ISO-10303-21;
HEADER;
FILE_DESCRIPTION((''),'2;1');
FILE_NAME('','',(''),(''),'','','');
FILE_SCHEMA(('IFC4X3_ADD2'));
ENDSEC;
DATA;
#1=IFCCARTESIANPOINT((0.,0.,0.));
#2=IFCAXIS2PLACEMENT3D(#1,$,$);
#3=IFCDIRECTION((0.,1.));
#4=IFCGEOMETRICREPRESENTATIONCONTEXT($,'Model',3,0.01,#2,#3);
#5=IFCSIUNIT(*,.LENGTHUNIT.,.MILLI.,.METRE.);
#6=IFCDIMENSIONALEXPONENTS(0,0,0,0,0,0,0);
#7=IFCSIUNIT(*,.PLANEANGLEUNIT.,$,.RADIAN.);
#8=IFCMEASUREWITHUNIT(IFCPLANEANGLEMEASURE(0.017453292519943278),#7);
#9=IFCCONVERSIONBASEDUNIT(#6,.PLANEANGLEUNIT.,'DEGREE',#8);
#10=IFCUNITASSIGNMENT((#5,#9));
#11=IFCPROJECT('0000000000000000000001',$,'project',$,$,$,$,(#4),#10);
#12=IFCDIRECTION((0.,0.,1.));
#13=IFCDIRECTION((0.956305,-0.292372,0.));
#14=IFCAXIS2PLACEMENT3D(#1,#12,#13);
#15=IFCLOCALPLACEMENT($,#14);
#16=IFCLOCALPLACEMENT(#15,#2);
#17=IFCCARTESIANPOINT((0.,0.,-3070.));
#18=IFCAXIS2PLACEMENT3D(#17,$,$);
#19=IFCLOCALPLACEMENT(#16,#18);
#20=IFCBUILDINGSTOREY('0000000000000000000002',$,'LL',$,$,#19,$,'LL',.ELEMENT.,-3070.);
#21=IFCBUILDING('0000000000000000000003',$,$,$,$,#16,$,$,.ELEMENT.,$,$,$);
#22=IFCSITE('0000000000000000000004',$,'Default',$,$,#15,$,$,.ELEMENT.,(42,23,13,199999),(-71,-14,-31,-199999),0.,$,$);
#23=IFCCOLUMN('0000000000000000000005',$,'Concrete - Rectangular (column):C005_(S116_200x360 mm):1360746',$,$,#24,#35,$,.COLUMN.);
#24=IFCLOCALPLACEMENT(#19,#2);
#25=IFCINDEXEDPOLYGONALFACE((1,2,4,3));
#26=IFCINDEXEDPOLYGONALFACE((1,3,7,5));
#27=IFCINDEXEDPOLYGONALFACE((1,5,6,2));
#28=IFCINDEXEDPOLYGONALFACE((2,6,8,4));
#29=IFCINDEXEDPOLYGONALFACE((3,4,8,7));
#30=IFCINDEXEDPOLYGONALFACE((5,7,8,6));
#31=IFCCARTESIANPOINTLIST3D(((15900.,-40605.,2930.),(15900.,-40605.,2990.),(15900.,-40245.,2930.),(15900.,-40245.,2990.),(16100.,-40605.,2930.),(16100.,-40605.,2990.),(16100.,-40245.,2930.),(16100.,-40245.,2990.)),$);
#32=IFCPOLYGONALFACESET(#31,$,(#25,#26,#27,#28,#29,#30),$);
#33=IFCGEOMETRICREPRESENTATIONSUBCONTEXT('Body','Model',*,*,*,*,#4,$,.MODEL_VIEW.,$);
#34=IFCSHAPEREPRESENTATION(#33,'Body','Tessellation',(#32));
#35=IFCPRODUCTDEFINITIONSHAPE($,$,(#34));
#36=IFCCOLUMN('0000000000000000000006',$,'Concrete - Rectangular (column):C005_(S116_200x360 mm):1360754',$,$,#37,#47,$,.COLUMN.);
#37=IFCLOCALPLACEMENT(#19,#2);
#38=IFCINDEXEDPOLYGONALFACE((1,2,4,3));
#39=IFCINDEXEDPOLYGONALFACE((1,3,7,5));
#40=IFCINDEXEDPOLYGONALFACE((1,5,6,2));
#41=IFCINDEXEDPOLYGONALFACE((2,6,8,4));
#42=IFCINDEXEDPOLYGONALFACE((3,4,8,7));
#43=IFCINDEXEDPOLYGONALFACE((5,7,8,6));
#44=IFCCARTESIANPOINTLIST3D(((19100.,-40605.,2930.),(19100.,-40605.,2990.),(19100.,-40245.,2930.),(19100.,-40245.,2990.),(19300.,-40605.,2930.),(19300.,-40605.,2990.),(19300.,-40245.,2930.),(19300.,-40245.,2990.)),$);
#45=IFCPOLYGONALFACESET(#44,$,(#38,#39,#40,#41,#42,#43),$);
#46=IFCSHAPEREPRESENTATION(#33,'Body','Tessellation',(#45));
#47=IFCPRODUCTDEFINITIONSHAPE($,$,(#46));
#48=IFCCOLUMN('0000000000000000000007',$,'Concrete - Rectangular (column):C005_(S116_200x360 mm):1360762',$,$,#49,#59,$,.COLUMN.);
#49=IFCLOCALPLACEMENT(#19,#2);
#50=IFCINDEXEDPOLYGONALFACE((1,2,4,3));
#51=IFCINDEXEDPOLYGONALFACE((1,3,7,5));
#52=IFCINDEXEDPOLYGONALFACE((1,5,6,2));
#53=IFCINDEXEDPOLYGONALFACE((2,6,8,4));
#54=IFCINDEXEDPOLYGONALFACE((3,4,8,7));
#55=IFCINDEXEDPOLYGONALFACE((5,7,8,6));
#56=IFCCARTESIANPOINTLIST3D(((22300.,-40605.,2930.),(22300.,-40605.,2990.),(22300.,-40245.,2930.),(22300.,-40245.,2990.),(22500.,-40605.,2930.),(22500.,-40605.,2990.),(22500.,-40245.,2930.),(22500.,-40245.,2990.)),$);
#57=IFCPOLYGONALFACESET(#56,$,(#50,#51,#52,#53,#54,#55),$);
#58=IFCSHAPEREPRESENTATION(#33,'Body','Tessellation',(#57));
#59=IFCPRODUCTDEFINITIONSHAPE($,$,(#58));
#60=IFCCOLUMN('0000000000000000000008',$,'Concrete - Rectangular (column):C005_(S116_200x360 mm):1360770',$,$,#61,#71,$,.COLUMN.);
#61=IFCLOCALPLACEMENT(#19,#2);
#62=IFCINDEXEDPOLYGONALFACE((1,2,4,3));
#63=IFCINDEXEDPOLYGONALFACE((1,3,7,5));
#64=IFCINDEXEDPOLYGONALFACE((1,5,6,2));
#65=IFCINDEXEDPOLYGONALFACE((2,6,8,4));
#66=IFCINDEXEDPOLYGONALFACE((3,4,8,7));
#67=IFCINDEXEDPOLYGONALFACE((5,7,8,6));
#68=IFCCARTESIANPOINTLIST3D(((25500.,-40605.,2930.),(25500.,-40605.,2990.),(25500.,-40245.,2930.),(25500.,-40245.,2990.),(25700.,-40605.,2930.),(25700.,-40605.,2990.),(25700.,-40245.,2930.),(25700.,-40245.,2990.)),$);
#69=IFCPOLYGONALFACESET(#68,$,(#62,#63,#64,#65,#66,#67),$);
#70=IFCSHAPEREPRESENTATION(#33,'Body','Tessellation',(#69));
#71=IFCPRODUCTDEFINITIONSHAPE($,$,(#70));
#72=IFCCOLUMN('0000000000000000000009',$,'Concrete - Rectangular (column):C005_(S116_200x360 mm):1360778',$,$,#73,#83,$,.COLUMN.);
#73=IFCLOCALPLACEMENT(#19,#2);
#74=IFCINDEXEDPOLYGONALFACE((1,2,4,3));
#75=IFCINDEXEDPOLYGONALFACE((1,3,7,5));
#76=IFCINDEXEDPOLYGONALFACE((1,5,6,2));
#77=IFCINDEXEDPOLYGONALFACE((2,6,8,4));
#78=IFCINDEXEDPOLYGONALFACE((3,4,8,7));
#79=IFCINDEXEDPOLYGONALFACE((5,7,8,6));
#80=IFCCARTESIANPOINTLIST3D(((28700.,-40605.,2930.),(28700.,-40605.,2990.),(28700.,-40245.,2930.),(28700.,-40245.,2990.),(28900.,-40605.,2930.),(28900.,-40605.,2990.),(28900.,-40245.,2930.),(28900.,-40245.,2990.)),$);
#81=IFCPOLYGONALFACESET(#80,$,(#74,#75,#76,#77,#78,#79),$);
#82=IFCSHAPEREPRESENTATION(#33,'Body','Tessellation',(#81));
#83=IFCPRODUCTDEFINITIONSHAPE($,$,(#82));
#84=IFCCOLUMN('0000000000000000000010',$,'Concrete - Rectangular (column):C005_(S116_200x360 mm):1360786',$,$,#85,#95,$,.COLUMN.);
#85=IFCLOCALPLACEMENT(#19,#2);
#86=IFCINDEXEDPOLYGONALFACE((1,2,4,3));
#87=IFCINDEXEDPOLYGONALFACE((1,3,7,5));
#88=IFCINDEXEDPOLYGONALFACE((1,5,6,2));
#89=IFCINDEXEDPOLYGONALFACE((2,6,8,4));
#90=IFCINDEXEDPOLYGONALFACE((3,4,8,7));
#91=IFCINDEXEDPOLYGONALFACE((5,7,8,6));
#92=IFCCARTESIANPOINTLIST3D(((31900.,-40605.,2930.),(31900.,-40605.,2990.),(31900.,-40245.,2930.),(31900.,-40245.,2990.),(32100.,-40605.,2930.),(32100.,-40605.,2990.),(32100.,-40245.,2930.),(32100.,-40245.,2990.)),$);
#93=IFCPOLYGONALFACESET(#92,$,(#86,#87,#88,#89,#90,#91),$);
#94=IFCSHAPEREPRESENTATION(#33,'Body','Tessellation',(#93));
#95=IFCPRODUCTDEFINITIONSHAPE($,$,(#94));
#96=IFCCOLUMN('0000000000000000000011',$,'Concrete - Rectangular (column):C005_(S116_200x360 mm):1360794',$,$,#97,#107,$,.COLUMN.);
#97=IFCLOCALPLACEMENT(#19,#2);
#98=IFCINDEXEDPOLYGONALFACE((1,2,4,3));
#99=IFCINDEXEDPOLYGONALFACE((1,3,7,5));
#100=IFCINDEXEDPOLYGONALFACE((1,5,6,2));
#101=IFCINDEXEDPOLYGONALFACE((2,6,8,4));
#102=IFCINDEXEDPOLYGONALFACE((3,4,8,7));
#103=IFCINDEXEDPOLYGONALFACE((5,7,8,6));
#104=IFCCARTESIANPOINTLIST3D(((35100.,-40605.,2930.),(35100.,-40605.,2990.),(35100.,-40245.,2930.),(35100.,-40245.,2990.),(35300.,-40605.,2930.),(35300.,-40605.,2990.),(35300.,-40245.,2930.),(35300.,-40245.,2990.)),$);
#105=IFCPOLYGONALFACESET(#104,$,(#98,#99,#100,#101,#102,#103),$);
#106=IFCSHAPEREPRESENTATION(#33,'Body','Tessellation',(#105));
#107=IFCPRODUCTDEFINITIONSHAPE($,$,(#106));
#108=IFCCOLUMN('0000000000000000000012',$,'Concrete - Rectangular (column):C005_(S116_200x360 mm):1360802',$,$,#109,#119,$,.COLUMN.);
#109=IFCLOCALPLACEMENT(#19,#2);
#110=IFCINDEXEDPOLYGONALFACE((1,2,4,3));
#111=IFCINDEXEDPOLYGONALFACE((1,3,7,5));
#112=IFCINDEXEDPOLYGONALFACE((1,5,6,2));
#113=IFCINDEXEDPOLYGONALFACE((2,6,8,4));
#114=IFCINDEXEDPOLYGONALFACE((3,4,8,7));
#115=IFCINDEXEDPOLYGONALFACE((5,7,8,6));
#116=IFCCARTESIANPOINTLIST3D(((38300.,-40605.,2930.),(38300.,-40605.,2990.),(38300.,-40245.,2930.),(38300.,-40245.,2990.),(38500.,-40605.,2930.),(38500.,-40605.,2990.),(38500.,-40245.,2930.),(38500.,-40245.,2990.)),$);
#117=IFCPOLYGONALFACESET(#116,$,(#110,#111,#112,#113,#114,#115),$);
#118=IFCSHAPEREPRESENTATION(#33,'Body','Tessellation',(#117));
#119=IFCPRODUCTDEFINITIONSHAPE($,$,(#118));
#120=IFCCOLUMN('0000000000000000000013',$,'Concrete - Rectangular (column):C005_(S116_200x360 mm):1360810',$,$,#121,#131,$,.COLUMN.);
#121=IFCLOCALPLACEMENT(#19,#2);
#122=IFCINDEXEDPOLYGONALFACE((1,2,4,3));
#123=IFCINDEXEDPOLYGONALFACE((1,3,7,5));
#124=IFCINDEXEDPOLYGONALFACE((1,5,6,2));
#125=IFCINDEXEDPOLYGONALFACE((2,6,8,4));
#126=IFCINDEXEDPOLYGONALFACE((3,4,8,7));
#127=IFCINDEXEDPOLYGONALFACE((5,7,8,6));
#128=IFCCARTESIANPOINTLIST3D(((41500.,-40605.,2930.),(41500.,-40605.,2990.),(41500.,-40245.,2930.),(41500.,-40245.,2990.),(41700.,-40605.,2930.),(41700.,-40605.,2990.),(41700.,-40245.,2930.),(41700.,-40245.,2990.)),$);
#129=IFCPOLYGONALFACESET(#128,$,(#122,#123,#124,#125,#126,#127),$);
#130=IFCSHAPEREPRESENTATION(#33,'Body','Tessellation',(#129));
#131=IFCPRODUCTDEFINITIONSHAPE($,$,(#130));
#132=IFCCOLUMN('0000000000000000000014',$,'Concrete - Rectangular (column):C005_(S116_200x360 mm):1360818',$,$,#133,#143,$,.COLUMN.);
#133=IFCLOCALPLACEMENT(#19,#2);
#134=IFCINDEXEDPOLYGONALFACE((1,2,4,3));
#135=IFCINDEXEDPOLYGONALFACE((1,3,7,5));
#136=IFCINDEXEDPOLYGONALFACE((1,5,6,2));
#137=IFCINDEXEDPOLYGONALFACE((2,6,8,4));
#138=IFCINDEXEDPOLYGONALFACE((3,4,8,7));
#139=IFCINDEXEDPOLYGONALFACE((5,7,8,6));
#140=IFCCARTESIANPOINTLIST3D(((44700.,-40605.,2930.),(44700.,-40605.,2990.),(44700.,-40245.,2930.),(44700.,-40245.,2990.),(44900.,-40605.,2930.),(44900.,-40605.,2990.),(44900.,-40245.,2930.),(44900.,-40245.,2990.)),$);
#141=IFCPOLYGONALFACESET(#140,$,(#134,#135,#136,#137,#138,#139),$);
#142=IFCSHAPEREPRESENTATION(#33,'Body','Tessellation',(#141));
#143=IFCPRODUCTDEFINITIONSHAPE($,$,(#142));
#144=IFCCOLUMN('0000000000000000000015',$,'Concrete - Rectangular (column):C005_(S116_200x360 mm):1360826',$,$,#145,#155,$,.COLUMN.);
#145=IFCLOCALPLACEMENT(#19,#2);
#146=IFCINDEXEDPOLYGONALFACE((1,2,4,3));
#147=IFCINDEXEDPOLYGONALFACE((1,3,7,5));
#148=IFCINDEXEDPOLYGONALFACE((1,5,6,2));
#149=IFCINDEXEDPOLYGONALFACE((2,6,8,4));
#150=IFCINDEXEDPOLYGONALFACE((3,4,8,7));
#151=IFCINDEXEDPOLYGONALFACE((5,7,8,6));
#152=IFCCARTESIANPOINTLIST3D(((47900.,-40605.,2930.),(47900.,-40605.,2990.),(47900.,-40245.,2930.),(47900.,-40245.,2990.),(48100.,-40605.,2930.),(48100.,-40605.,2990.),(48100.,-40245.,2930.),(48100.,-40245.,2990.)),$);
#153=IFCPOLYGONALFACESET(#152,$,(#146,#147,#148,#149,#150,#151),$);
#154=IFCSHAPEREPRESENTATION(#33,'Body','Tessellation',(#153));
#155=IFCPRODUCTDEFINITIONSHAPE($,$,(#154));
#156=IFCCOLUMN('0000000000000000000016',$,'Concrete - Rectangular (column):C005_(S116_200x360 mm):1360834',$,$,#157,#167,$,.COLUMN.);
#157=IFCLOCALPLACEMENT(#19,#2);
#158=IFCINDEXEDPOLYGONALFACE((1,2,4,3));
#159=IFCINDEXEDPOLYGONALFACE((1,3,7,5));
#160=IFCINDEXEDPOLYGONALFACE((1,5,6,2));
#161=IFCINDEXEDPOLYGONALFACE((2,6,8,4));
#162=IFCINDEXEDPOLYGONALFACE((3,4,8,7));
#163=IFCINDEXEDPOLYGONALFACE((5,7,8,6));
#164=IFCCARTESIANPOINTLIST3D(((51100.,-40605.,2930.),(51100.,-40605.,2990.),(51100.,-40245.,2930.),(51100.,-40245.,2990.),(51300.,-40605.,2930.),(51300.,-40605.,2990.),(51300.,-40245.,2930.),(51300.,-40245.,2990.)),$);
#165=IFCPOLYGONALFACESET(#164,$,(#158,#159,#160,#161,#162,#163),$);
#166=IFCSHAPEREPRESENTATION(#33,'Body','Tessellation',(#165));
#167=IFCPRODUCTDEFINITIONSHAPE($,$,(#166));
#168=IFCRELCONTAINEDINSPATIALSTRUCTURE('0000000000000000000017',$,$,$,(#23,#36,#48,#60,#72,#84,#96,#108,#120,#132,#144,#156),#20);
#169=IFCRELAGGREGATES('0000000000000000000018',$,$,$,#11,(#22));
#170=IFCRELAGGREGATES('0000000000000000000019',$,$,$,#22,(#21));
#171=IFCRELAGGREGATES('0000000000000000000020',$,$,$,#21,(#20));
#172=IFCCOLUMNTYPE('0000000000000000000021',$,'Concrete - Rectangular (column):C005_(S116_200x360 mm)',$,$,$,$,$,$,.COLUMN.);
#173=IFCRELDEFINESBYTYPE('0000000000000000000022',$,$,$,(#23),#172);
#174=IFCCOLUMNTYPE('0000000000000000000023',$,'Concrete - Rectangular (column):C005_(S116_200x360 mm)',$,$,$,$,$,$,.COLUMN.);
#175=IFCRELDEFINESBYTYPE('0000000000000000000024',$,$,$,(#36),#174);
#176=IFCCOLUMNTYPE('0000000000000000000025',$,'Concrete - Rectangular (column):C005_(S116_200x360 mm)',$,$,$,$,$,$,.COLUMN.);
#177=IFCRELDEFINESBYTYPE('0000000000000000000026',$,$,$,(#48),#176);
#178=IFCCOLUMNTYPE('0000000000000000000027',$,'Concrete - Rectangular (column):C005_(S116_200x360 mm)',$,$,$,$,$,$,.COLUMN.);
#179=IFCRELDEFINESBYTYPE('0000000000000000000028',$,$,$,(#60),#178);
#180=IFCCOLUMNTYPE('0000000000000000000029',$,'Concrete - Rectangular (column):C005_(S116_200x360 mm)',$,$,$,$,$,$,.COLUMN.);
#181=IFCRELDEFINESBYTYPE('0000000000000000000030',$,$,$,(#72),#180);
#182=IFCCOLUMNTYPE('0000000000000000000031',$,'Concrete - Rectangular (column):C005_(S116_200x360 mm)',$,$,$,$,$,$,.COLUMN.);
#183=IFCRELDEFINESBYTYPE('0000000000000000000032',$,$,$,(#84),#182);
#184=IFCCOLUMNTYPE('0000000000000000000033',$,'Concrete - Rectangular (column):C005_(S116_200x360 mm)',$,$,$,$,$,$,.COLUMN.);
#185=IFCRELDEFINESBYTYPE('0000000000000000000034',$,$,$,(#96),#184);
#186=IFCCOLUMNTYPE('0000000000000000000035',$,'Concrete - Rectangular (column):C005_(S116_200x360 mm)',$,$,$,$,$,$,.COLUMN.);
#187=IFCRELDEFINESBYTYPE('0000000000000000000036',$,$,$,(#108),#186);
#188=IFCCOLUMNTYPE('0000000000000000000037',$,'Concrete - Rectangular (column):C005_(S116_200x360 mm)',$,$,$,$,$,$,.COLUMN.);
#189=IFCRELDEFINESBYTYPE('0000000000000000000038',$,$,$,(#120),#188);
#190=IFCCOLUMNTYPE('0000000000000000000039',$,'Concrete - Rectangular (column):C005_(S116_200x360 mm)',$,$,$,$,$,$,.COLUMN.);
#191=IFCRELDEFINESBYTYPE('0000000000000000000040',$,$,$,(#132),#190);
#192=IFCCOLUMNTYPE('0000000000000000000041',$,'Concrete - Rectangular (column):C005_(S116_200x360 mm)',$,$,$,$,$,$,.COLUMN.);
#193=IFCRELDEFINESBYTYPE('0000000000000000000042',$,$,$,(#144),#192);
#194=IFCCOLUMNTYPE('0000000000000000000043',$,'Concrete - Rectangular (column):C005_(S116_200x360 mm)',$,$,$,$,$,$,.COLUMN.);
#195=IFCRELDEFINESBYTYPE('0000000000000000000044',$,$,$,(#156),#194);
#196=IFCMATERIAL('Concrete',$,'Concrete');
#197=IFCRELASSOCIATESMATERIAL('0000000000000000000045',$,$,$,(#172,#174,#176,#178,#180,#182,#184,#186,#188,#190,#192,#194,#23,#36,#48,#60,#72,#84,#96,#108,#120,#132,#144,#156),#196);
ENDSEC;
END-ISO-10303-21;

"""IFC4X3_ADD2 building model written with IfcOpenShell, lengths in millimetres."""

from ifc_helpers import new_model, entity, si_unit, converted_unit, direction, frame, frame_2d, origin, place, context, subcontext, project, spatial, rectangle, extrude, source, transform, mapped, material, material_profile, profile_set, profile_usage, type_object, type_shapes, element, save


model = new_model("IFC4X3_ADD2")

# Units and contexts
model_context = context("Model", 3, precision=0.01, world=origin(), true_north=direction((0.0, 1.0)))
body_context = subcontext(model_context, "Body", "Model", "MODEL_VIEW")
ifc_project = project(units=[si_unit("LENGTHUNIT", "METRE", prefix="MILLI"), converted_unit("PLANEANGLEUNIT", "DEGREE", entity("IfcPlaneAngleMeasure", 0.017453292519943278), si_unit("PLANEANGLEUNIT", "RADIAN"), dimensions=[0, 0, 0, 0, 0, 0, 0])], contexts=[model_context])

# Site, building, storey
site_placement = place(None, frame((0.0, 0.0, 0.0), z_axis=(0.0, 0.0, 1.0), x_axis=(0.956305, -0.292372, 0.0)))
site = spatial("IfcSite", under=ifc_project, at=site_placement, Name="Default", CompositionType="ELEMENT", RefLatitude=(42, 23, 13, 199999), RefLongitude=(-71, -14, -31, -199999), RefElevation=0.0)
building_placement = place(site_placement, origin())
building = spatial("IfcBuilding", under=site, at=building_placement, CompositionType="ELEMENT")
storey_placement = place(building_placement, frame((0.0, 0.0, -3070.0)))
storey = spatial("IfcBuildingStorey", under=building, at=storey_placement, Name="LL", LongName="LL", CompositionType="ELEMENT", Elevation=-3070.0)

# Columns
ifc_material_1 = material(Name="Concrete", Category="Concrete")
ifc_material_profile_1 = material_profile(ifc_material_1, rectangle(XDim=200.0, YDim=360.0, at=frame_2d((0.0, 0.0), x_axis=(1.0, 0.0))), Name="C005_(S116_200x360 mm)")
ifc_profile_set_1 = profile_set([ifc_material_profile_1], Name="C005_(S116_200x360 mm)")
ifc_profile_usage_1 = profile_usage(ifc_profile_set_1)
column_type_1 = type_object("IfcColumnType", Name="Concrete - Rectangular (column):C005_(S116_200x360 mm)", PredefinedType="COLUMN", material=ifc_profile_set_1)
shared_shape_1 = source(origin(), body_context, "Body", "SweptSolid", [
    extrude(rectangle(XDim=200.0, YDim=360.0, at=frame_2d((0.0, 0.0), x_axis=(1.0, 0.0))), frame((16000.0, -40425.0, -140.0), z_axis=(0.0, 0.0, 1.0), x_axis=(-1.0, 0.0, 0.0)), (0.0, 0.0, 1.0), 60.0),
])
type_shapes(column_type_1, [shared_shape_1])
column_1_placement = place(storey_placement, frame((0.0, 0.0, 3070.0)))
element("IfcColumn", 1, at=column_1_placement, inside=storey, type_object=column_type_1, material=ifc_profile_usage_1, Name="Concrete - Rectangular (column):C005_(S116_200x360 mm):1360746", PredefinedType="COLUMN", context=body_context, shape_type="MappedRepresentation", body=[
    mapped(shared_shape_1, transform((0.0, 0.0, 0.0), scale=1.0)),
])
column_type_2 = type_object("IfcColumnType", Name="Concrete - Rectangular (column):C005_(S116_200x360 mm)", PredefinedType="COLUMN", material=ifc_profile_set_1)
shared_shape_2 = source(origin(), body_context, "Body", "SweptSolid", [
    extrude(rectangle(XDim=200.0, YDim=360.0, at=frame_2d((0.0, 0.0), x_axis=(1.0, 0.0))), frame((19200.0, -40425.0, -140.0), z_axis=(0.0, 0.0, 1.0), x_axis=(-1.0, 0.0, 0.0)), (0.0, 0.0, 1.0), 60.0),
])
type_shapes(column_type_2, [shared_shape_2])
column_2_placement = place(storey_placement, frame((0.0, 0.0, 3070.0)))
element("IfcColumn", 2, at=column_2_placement, inside=storey, type_object=column_type_2, material=ifc_profile_usage_1, Name="Concrete - Rectangular (column):C005_(S116_200x360 mm):1360754", PredefinedType="COLUMN", context=body_context, shape_type="MappedRepresentation", body=[
    mapped(shared_shape_2, transform((0.0, 0.0, 0.0), scale=1.0)),
])
column_type_3 = type_object("IfcColumnType", Name="Concrete - Rectangular (column):C005_(S116_200x360 mm)", PredefinedType="COLUMN", material=ifc_profile_set_1)
shared_shape_3 = source(origin(), body_context, "Body", "SweptSolid", [
    extrude(rectangle(XDim=200.0, YDim=360.0, at=frame_2d((0.0, 0.0), x_axis=(1.0, 0.0))), frame((22400.0, -40425.0, -140.0), z_axis=(0.0, 0.0, 1.0), x_axis=(-1.0, 0.0, 0.0)), (0.0, 0.0, 1.0), 60.0),
])
type_shapes(column_type_3, [shared_shape_3])
column_3_placement = place(storey_placement, frame((0.0, 0.0, 3070.0)))
element("IfcColumn", 3, at=column_3_placement, inside=storey, type_object=column_type_3, material=ifc_profile_usage_1, Name="Concrete - Rectangular (column):C005_(S116_200x360 mm):1360762", PredefinedType="COLUMN", context=body_context, shape_type="MappedRepresentation", body=[
    mapped(shared_shape_3, transform((0.0, 0.0, 0.0), scale=1.0)),
])
column_type_4 = type_object("IfcColumnType", Name="Concrete - Rectangular (column):C005_(S116_200x360 mm)", PredefinedType="COLUMN", material=ifc_profile_set_1)
shared_shape_4 = source(origin(), body_context, "Body", "SweptSolid", [
    extrude(rectangle(XDim=200.0, YDim=360.0, at=frame_2d((0.0, 0.0), x_axis=(1.0, 0.0))), frame((25600.0, -40425.0, -140.0), z_axis=(0.0, 0.0, 1.0), x_axis=(-1.0, 0.0, 0.0)), (0.0, 0.0, 1.0), 60.0),
])
type_shapes(column_type_4, [shared_shape_4])
column_4_placement = place(storey_placement, frame((0.0, 0.0, 3070.0)))
element("IfcColumn", 4, at=column_4_placement, inside=storey, type_object=column_type_4, material=ifc_profile_usage_1, Name="Concrete - Rectangular (column):C005_(S116_200x360 mm):1360770", PredefinedType="COLUMN", context=body_context, shape_type="MappedRepresentation", body=[
    mapped(shared_shape_4, transform((0.0, 0.0, 0.0), scale=1.0)),
])
column_type_5 = type_object("IfcColumnType", Name="Concrete - Rectangular (column):C005_(S116_200x360 mm)", PredefinedType="COLUMN", material=ifc_profile_set_1)
shared_shape_5 = source(origin(), body_context, "Body", "SweptSolid", [
    extrude(rectangle(XDim=200.0, YDim=360.0, at=frame_2d((0.0, 0.0), x_axis=(1.0, 0.0))), frame((28800.0, -40425.0, -140.0), z_axis=(0.0, 0.0, 1.0), x_axis=(-1.0, 0.0, 0.0)), (0.0, 0.0, 1.0), 60.0),
])
type_shapes(column_type_5, [shared_shape_5])
column_5_placement = place(storey_placement, frame((0.0, 0.0, 3070.0)))
element("IfcColumn", 5, at=column_5_placement, inside=storey, type_object=column_type_5, material=ifc_profile_usage_1, Name="Concrete - Rectangular (column):C005_(S116_200x360 mm):1360778", PredefinedType="COLUMN", context=body_context, shape_type="MappedRepresentation", body=[
    mapped(shared_shape_5, transform((0.0, 0.0, 0.0), scale=1.0)),
])
column_type_6 = type_object("IfcColumnType", Name="Concrete - Rectangular (column):C005_(S116_200x360 mm)", PredefinedType="COLUMN", material=ifc_profile_set_1)
shared_shape_6 = source(origin(), body_context, "Body", "SweptSolid", [
    extrude(rectangle(XDim=200.0, YDim=360.0, at=frame_2d((0.0, 0.0), x_axis=(1.0, 0.0))), frame((32000.0, -40425.0, -140.0), z_axis=(0.0, 0.0, 1.0), x_axis=(-1.0, 0.0, 0.0)), (0.0, 0.0, 1.0), 60.0),
])
type_shapes(column_type_6, [shared_shape_6])
column_6_placement = place(storey_placement, frame((0.0, 0.0, 3070.0)))
element("IfcColumn", 6, at=column_6_placement, inside=storey, type_object=column_type_6, material=ifc_profile_usage_1, Name="Concrete - Rectangular (column):C005_(S116_200x360 mm):1360786", PredefinedType="COLUMN", context=body_context, shape_type="MappedRepresentation", body=[
    mapped(shared_shape_6, transform((0.0, 0.0, 0.0), scale=1.0)),
])
column_type_7 = type_object("IfcColumnType", Name="Concrete - Rectangular (column):C005_(S116_200x360 mm)", PredefinedType="COLUMN", material=ifc_profile_set_1)
shared_shape_7 = source(origin(), body_context, "Body", "SweptSolid", [
    extrude(rectangle(XDim=200.0, YDim=360.0, at=frame_2d((0.0, 0.0), x_axis=(1.0, 0.0))), frame((35200.0, -40425.0, -140.0), z_axis=(0.0, 0.0, 1.0), x_axis=(-1.0, 0.0, 0.0)), (0.0, 0.0, 1.0), 60.0),
])
type_shapes(column_type_7, [shared_shape_7])
column_7_placement = place(storey_placement, frame((0.0, 0.0, 3070.0)))
element("IfcColumn", 7, at=column_7_placement, inside=storey, type_object=column_type_7, material=ifc_profile_usage_1, Name="Concrete - Rectangular (column):C005_(S116_200x360 mm):1360794", PredefinedType="COLUMN", context=body_context, shape_type="MappedRepresentation", body=[
    mapped(shared_shape_7, transform((0.0, 0.0, 0.0), scale=1.0)),
])
column_type_8 = type_object("IfcColumnType", Name="Concrete - Rectangular (column):C005_(S116_200x360 mm)", PredefinedType="COLUMN", material=ifc_profile_set_1)
shared_shape_8 = source(origin(), body_context, "Body", "SweptSolid", [
    extrude(rectangle(XDim=200.0, YDim=360.0, at=frame_2d((0.0, 0.0), x_axis=(1.0, 0.0))), frame((38400.0, -40425.0, -140.0), z_axis=(0.0, 0.0, 1.0), x_axis=(-1.0, 0.0, 0.0)), (0.0, 0.0, 1.0), 60.0),
])
type_shapes(column_type_8, [shared_shape_8])
column_8_placement = place(storey_placement, frame((0.0, 0.0, 3070.0)))
element("IfcColumn", 8, at=column_8_placement, inside=storey, type_object=column_type_8, material=ifc_profile_usage_1, Name="Concrete - Rectangular (column):C005_(S116_200x360 mm):1360802", PredefinedType="COLUMN", context=body_context, shape_type="MappedRepresentation", body=[
    mapped(shared_shape_8, transform((0.0, 0.0, 0.0), scale=1.0)),
])
column_type_9 = type_object("IfcColumnType", Name="Concrete - Rectangular (column):C005_(S116_200x360 mm)", PredefinedType="COLUMN", material=ifc_profile_set_1)
shared_shape_9 = source(origin(), body_context, "Body", "SweptSolid", [
    extrude(rectangle(XDim=200.0, YDim=360.0, at=frame_2d((0.0, 0.0), x_axis=(1.0, 0.0))), frame((41600.0, -40425.0, -140.0), z_axis=(0.0, 0.0, 1.0), x_axis=(-1.0, 0.0, 0.0)), (0.0, 0.0, 1.0), 60.0),
])
type_shapes(column_type_9, [shared_shape_9])
column_9_placement = place(storey_placement, frame((0.0, 0.0, 3070.0)))
element("IfcColumn", 9, at=column_9_placement, inside=storey, type_object=column_type_9, material=ifc_profile_usage_1, Name="Concrete - Rectangular (column):C005_(S116_200x360 mm):1360810", PredefinedType="COLUMN", context=body_context, shape_type="MappedRepresentation", body=[
    mapped(shared_shape_9, transform((0.0, 0.0, 0.0), scale=1.0)),
])
column_type_10 = type_object("IfcColumnType", Name="Concrete - Rectangular (column):C005_(S116_200x360 mm)", PredefinedType="COLUMN", material=ifc_profile_set_1)
shared_shape_10 = source(origin(), body_context, "Body", "SweptSolid", [
    extrude(rectangle(XDim=200.0, YDim=360.0, at=frame_2d((0.0, 0.0), x_axis=(1.0, 0.0))), frame((44800.0, -40425.0, -140.0), z_axis=(0.0, 0.0, 1.0), x_axis=(-1.0, 0.0, 0.0)), (0.0, 0.0, 1.0), 60.0),
])
type_shapes(column_type_10, [shared_shape_10])
column_10_placement = place(storey_placement, frame((0.0, 0.0, 3070.0)))
element("IfcColumn", 10, at=column_10_placement, inside=storey, type_object=column_type_10, material=ifc_profile_usage_1, Name="Concrete - Rectangular (column):C005_(S116_200x360 mm):1360818", PredefinedType="COLUMN", context=body_context, shape_type="MappedRepresentation", body=[
    mapped(shared_shape_10, transform((0.0, 0.0, 0.0), scale=1.0)),
])
column_type_11 = type_object("IfcColumnType", Name="Concrete - Rectangular (column):C005_(S116_200x360 mm)", PredefinedType="COLUMN", material=ifc_profile_set_1)
shared_shape_11 = source(origin(), body_context, "Body", "SweptSolid", [
    extrude(rectangle(XDim=200.0, YDim=360.0, at=frame_2d((0.0, 0.0), x_axis=(1.0, 0.0))), frame((48000.0, -40425.0, -140.0), z_axis=(0.0, 0.0, 1.0), x_axis=(-1.0, 0.0, 0.0)), (0.0, 0.0, 1.0), 60.0),
])
type_shapes(column_type_11, [shared_shape_11])
column_11_placement = place(storey_placement, frame((0.0, 0.0, 3070.0)))
element("IfcColumn", 11, at=column_11_placement, inside=storey, type_object=column_type_11, material=ifc_profile_usage_1, Name="Concrete - Rectangular (column):C005_(S116_200x360 mm):1360826", PredefinedType="COLUMN", context=body_context, shape_type="MappedRepresentation", body=[
    mapped(shared_shape_11, transform((0.0, 0.0, 0.0), scale=1.0)),
])
column_type_12 = type_object("IfcColumnType", Name="Concrete - Rectangular (column):C005_(S116_200x360 mm)", PredefinedType="COLUMN", material=ifc_profile_set_1)
shared_shape_12 = source(origin(), body_context, "Body", "SweptSolid", [
    extrude(rectangle(XDim=200.0, YDim=360.0, at=frame_2d((0.0, 0.0), x_axis=(1.0, 0.0))), frame((51200.0, -40425.0, -140.0), z_axis=(0.0, 0.0, 1.0), x_axis=(-1.0, 0.0, 0.0)), (0.0, 0.0, 1.0), 60.0),
])
type_shapes(column_type_12, [shared_shape_12])
column_12_placement = place(storey_placement, frame((0.0, 0.0, 3070.0)))
element("IfcColumn", 12, at=column_12_placement, inside=storey, type_object=column_type_12, material=ifc_profile_usage_1, Name="Concrete - Rectangular (column):C005_(S116_200x360 mm):1360834", PredefinedType="COLUMN", context=body_context, shape_type="MappedRepresentation", body=[
    mapped(shared_shape_12, transform((0.0, 0.0, 0.0), scale=1.0)),
])

save(model, "model.ifc")
